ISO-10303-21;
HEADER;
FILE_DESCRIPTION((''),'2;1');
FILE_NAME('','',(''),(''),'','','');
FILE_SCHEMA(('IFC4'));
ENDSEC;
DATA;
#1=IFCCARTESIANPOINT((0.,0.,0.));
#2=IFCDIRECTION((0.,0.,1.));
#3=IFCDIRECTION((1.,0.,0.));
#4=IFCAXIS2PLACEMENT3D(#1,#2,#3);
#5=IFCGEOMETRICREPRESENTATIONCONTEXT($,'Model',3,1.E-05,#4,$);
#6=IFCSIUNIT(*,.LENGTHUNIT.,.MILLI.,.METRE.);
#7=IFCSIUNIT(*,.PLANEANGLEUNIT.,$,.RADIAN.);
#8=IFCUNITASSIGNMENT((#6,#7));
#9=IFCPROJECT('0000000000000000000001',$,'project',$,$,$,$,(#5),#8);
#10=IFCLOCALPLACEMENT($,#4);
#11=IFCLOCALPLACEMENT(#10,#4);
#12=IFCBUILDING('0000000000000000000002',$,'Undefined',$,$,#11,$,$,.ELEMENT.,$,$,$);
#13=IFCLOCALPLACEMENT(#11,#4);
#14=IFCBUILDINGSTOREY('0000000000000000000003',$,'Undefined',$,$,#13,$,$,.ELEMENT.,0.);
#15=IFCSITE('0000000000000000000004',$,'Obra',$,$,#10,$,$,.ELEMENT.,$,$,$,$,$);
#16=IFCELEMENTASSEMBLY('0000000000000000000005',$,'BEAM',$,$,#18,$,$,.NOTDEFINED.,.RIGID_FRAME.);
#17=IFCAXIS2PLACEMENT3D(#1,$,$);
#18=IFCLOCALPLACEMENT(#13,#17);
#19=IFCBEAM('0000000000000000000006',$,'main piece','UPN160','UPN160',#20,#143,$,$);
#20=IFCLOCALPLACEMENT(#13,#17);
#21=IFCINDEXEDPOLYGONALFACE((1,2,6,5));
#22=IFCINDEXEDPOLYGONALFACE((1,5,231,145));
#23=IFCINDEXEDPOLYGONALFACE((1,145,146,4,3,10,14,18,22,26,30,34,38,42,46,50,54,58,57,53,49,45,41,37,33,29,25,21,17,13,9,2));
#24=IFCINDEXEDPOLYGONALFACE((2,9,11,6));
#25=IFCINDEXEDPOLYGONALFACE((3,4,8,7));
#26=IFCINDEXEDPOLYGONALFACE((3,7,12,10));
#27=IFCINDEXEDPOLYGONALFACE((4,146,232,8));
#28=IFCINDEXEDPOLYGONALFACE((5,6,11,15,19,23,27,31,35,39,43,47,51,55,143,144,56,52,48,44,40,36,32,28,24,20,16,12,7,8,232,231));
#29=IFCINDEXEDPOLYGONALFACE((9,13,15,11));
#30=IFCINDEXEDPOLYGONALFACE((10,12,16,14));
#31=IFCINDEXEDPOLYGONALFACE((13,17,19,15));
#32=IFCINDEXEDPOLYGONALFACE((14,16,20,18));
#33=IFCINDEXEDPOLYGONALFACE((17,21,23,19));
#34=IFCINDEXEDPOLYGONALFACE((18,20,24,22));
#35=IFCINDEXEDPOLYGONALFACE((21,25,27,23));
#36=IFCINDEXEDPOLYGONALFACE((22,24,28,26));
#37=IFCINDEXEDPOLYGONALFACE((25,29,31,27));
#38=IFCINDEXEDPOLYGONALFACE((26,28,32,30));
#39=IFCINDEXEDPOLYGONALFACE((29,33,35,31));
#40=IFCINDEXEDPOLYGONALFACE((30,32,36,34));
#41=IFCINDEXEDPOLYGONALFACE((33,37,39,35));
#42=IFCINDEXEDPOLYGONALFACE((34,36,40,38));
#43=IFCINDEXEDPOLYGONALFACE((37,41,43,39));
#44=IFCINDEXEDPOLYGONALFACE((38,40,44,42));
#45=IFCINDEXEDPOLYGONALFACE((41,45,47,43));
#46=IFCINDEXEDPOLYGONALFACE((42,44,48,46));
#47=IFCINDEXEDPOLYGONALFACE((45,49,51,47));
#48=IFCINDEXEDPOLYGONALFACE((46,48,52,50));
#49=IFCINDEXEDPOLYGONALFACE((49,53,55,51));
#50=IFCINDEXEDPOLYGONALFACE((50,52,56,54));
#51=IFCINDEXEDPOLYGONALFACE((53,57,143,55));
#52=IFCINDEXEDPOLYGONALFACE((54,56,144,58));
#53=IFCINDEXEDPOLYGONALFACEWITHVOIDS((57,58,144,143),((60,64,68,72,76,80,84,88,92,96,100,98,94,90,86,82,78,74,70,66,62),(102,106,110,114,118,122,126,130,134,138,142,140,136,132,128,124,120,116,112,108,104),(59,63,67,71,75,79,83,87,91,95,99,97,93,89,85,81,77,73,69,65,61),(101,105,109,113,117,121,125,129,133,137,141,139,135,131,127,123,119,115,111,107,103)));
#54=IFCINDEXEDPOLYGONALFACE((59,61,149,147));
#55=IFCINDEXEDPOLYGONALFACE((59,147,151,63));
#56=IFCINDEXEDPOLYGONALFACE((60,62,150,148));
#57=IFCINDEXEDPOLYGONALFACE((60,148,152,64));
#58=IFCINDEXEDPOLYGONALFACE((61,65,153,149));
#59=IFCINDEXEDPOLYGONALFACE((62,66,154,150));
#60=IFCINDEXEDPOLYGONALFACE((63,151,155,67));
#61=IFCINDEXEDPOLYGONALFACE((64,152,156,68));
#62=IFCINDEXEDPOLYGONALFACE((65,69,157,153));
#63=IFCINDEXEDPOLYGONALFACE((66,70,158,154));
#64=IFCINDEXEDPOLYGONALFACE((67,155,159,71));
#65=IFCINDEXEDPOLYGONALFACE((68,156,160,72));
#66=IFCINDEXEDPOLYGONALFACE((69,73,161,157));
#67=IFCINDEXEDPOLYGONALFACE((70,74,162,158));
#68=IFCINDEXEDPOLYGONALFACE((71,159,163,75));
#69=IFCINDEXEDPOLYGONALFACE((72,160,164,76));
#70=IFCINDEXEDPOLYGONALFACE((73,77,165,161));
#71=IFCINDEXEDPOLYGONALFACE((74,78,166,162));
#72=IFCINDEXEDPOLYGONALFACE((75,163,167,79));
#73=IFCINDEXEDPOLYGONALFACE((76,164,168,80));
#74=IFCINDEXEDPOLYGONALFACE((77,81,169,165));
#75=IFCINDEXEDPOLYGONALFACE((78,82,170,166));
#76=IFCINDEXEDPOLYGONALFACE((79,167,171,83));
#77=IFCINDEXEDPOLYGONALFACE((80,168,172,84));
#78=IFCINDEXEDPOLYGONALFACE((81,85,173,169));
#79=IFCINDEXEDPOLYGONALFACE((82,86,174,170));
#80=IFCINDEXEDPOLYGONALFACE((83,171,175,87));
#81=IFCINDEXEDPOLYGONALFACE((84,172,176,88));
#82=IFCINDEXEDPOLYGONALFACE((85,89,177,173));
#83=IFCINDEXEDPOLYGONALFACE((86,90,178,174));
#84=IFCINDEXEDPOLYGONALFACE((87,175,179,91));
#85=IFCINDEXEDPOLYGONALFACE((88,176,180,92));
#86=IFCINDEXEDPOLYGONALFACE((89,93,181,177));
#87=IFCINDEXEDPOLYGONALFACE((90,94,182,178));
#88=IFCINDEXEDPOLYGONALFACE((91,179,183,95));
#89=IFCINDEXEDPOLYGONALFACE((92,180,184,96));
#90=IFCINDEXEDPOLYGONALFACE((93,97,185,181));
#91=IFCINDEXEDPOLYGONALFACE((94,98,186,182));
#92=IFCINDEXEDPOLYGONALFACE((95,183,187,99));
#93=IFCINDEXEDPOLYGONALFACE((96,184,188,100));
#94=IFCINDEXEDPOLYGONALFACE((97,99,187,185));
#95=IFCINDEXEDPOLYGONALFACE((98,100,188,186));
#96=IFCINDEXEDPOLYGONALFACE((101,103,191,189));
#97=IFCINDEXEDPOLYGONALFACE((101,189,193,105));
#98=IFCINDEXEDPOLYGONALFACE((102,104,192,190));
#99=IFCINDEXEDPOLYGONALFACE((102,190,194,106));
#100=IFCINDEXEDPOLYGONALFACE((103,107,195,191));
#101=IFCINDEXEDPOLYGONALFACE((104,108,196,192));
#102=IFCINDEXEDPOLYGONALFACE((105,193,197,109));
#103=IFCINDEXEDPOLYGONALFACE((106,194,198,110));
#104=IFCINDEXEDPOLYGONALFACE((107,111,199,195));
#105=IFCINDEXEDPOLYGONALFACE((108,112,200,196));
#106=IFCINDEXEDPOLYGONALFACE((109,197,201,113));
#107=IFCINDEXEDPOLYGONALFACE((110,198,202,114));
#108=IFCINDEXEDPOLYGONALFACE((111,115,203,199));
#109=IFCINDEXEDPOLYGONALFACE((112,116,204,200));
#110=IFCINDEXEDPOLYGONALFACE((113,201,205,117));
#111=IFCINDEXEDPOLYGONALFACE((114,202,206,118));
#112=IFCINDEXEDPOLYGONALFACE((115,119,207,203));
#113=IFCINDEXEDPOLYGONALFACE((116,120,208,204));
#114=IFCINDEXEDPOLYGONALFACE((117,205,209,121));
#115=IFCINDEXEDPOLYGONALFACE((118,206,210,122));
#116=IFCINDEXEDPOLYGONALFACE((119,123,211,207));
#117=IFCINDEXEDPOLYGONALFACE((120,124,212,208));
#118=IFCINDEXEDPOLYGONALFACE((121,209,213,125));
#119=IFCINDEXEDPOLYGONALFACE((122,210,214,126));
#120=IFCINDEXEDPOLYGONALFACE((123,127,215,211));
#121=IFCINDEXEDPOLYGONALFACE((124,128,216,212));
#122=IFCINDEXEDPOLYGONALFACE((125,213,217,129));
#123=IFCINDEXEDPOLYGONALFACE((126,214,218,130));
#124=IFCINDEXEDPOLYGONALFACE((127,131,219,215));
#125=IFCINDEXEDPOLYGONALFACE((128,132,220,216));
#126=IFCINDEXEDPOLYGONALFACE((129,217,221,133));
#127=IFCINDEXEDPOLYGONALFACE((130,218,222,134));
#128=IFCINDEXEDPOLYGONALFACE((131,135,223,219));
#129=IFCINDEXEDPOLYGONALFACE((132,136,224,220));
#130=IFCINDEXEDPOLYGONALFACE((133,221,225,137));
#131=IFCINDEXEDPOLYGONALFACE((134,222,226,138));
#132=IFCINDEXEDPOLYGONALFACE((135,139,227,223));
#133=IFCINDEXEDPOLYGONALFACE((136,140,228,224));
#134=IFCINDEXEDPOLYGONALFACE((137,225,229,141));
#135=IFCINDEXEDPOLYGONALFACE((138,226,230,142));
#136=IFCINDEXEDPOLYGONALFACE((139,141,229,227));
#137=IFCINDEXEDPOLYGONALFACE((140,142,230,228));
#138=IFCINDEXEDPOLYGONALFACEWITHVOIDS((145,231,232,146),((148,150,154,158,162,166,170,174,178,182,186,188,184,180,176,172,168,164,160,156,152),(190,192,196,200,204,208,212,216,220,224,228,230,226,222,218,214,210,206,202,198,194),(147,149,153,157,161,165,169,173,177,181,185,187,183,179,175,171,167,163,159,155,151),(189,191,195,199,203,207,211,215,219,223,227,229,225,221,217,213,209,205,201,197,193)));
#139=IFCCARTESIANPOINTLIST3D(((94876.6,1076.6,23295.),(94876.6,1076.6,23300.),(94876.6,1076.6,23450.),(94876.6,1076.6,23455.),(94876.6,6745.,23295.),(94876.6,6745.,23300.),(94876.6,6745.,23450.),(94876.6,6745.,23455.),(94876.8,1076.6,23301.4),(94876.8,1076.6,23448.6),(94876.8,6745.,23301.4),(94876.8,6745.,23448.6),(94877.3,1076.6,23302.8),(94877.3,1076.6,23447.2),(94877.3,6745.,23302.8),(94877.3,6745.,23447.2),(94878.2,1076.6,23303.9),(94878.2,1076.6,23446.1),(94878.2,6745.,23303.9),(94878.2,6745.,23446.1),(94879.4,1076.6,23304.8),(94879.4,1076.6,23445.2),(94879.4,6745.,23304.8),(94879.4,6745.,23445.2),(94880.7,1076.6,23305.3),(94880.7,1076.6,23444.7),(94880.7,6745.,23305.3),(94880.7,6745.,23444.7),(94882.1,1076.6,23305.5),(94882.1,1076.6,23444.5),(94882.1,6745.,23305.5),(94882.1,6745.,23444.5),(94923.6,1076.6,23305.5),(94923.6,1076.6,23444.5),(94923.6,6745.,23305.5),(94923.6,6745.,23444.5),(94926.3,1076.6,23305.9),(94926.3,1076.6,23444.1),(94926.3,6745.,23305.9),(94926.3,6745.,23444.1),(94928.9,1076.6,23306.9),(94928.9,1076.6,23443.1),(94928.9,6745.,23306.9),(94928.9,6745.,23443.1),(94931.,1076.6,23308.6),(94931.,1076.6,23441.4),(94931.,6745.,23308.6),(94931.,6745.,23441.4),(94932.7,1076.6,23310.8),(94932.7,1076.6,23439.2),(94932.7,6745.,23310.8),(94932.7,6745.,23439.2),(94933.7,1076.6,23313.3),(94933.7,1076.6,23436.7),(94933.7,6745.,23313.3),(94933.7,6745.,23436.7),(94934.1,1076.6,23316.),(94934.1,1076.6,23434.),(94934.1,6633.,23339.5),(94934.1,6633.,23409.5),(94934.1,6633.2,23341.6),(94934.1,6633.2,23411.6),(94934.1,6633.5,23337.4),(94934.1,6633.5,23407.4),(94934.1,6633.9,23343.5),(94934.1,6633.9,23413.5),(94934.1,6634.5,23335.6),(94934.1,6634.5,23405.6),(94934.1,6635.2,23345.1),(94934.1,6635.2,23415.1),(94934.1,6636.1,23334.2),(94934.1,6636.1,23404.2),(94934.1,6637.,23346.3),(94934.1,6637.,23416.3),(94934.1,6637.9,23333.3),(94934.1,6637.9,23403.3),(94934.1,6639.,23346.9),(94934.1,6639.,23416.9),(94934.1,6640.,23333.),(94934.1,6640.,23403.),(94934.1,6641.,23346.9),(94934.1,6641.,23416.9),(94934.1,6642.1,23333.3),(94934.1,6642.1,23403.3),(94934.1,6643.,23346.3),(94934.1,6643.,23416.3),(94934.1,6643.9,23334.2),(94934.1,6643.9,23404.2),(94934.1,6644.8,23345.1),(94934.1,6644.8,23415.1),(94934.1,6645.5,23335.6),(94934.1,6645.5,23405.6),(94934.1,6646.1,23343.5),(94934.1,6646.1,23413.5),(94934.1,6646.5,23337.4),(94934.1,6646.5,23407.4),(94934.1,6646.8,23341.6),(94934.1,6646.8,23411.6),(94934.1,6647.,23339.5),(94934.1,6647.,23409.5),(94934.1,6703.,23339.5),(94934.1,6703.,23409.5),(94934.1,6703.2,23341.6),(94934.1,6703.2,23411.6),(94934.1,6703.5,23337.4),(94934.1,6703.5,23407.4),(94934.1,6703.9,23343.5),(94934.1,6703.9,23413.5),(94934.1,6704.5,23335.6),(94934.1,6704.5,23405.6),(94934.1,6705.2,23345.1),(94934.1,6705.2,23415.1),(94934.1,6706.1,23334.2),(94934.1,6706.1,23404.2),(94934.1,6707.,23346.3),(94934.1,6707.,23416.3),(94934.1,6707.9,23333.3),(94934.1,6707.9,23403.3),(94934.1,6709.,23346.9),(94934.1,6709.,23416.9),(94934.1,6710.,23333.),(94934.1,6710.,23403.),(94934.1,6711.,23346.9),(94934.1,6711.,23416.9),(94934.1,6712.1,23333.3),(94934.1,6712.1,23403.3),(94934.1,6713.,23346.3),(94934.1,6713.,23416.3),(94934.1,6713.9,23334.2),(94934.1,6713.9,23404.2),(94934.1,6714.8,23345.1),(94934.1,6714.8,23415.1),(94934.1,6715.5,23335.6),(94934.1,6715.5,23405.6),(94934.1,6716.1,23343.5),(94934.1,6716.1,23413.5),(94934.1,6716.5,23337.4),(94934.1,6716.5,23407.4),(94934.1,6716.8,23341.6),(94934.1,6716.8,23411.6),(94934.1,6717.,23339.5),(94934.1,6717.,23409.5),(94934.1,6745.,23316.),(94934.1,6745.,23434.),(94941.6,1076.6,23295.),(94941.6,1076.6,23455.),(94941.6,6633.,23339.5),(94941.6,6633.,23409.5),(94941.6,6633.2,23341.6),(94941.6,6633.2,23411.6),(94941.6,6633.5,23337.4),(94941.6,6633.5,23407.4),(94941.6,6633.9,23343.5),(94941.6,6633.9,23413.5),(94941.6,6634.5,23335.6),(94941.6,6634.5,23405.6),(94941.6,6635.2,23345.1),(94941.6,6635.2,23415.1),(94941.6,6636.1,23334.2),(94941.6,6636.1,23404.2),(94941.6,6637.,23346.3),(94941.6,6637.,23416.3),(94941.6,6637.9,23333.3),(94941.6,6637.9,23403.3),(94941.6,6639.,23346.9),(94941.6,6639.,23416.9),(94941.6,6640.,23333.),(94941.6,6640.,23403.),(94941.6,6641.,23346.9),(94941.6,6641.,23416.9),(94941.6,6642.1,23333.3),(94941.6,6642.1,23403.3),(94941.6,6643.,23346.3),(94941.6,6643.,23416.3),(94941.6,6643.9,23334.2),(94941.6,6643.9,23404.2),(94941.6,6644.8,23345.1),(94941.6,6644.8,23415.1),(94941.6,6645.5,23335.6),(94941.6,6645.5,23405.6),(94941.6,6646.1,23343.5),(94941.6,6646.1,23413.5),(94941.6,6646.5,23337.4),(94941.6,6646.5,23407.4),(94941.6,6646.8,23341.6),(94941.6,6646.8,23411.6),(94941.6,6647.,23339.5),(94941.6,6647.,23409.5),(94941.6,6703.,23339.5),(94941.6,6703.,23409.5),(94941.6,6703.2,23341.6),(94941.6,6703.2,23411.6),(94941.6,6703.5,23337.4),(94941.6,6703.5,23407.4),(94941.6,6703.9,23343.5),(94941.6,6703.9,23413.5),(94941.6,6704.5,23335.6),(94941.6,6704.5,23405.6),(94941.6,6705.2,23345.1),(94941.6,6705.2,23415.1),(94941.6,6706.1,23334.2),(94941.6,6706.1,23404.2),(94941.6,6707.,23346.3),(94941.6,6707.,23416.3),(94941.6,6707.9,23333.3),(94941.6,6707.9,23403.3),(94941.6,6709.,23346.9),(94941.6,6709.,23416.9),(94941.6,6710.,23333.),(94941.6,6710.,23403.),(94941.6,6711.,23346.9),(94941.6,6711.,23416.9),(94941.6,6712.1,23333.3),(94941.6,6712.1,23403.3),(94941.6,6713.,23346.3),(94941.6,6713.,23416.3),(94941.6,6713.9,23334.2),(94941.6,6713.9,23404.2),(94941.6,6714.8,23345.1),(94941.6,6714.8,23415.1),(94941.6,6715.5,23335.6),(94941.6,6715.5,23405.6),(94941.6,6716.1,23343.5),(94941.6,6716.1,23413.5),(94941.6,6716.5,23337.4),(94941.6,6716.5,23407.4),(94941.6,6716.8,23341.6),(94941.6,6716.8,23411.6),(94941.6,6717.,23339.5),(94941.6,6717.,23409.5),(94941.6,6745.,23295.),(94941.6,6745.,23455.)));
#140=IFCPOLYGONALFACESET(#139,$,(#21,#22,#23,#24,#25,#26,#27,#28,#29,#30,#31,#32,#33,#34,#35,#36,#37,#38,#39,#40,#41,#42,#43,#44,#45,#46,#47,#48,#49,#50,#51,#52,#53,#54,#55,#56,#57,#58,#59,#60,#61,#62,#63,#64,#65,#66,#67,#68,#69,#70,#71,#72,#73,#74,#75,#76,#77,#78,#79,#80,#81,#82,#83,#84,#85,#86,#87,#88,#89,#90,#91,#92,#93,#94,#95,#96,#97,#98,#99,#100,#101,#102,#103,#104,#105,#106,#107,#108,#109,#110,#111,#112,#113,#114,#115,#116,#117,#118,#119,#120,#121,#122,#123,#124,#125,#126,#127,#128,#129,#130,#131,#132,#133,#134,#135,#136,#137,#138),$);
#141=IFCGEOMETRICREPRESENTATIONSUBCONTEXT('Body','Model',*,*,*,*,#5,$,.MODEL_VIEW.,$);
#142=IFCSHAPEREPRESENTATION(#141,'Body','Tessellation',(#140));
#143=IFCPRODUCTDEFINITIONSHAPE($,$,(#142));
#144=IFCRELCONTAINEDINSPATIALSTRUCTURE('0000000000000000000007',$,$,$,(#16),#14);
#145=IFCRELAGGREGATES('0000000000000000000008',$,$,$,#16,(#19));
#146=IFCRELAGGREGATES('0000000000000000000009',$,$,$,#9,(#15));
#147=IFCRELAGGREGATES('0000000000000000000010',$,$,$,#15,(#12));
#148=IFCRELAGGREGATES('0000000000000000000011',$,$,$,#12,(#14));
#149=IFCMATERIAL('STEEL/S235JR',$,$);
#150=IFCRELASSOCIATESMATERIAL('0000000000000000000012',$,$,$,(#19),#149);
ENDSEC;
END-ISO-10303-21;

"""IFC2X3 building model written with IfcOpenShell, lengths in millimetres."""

from ifc_helpers import new_model, si_unit, frame, origin_with_axes, origin_2d_with_axis, place, context, subcontext, project, spatial, circle, u_section, extrude, clip, halfspace, source, transform, mapped, material, element, aggregate, save


model = new_model("IFC2X3")

# Units and contexts
model_context = context("Model", 3, precision=1e-05, world=origin_with_axes())
body_context = subcontext(model_context, "Body", "Model", "MODEL_VIEW")
ifc_project = project(units=[si_unit("LENGTHUNIT", "METRE", prefix="MILLI"), si_unit("PLANEANGLEUNIT", "RADIAN")], contexts=[model_context])

# Site, building, storey
site_placement = place(None, origin_with_axes())
site = spatial("IfcSite", under=ifc_project, at=site_placement, Name="Obra", CompositionType="ELEMENT")
building_placement = place(site_placement, origin_with_axes())
building = spatial("IfcBuilding", under=site, at=building_placement, Name="Undefined", CompositionType="ELEMENT")
storey_placement = place(building_placement, origin_with_axes())
storey = spatial("IfcBuildingStorey", under=building, at=storey_placement, Name="Undefined", CompositionType="ELEMENT", Elevation=0.0)

# Shared definitions
ifc_material_1 = material(Name="STEEL/S235JR")

# Element assembly, beam, opening
assembly_1_placement = place(storey_placement, origin_with_axes())
assembly_1 = element("IfcElementAssembly", 1, at=assembly_1_placement, inside=storey, Name="BEAM", AssemblyPlace="NOTDEFINED", PredefinedType="RIGID_FRAME")
beam_1_placement = place(assembly_1_placement, frame((94909.1, 6750.0, 23375.0), z_axis=(0.0, 0.0, 1.0), x_axis=(0.0, -1.0, 0.0)))
beam_1 = element("IfcBeam", 2, at=beam_1_placement, material=ifc_material_1, Name="main piece", Description="UPN160", ObjectType="UPN160", context=body_context, shape_type="Clipping", body=[
    clip(clip(extrude(u_section(Depth=160.0, FlangeWidth=65.0, WebThickness=7.5, FlangeThickness=10.5, FilletRadius=10.5, EdgeRadius=5.5, at=origin_2d_with_axis()), frame((5673.4, 0.0, 0.0), z_axis=(-1.0, 0.0, 0.0), x_axis=(0.0, -1.0, 0.0)), (0.0, 0.0, 1.0), 5668.4), halfspace(frame((5673.4, 0.0, -180.0), z_axis=(-1.0, 0.0, 0.0), x_axis=(0.0, 1.0, 0.0)), True)), halfspace(frame((5.0, 0.0, 166.3), z_axis=(-1.0, 0.0, 0.0), x_axis=(0.0, -1.0, 0.0)), False)),
])
shared_shape_1 = source(origin_with_axes(), body_context, "Body", "SweptSolid", [
    extrude(circle(Radius=7.0, at=origin_2d_with_axis()), frame((0.0, -3.9, 0.0), z_axis=(0.0, 1.0, 0.0), x_axis=(1.0, 0.0, 0.0)), (0.0, 0.0, 1.0), 7.7),
])
opening_1_placement = place(assembly_1_placement, frame((94937.9, 6710.0, 23410.0), z_axis=(0.0, -1.0, 0.0), x_axis=(0.0, 0.0, -1.0)))
element("IfcOpeningElement", 3, at=opening_1_placement, cuts=beam_1, ObjectType="Opening", context=body_context, shape_type="MappedRepresentation", body=[
    mapped(shared_shape_1, transform((0.0, 0.0, 0.0))),
    mapped(shared_shape_1, transform((0.0, 0.0, 70.0))),
    mapped(shared_shape_1, transform((70.0, 0.0, 0.0))),
    mapped(shared_shape_1, transform((70.0, 0.0, 70.0))),
])
aggregate(assembly_1, [beam_1])

save(model, "model.ifc")
